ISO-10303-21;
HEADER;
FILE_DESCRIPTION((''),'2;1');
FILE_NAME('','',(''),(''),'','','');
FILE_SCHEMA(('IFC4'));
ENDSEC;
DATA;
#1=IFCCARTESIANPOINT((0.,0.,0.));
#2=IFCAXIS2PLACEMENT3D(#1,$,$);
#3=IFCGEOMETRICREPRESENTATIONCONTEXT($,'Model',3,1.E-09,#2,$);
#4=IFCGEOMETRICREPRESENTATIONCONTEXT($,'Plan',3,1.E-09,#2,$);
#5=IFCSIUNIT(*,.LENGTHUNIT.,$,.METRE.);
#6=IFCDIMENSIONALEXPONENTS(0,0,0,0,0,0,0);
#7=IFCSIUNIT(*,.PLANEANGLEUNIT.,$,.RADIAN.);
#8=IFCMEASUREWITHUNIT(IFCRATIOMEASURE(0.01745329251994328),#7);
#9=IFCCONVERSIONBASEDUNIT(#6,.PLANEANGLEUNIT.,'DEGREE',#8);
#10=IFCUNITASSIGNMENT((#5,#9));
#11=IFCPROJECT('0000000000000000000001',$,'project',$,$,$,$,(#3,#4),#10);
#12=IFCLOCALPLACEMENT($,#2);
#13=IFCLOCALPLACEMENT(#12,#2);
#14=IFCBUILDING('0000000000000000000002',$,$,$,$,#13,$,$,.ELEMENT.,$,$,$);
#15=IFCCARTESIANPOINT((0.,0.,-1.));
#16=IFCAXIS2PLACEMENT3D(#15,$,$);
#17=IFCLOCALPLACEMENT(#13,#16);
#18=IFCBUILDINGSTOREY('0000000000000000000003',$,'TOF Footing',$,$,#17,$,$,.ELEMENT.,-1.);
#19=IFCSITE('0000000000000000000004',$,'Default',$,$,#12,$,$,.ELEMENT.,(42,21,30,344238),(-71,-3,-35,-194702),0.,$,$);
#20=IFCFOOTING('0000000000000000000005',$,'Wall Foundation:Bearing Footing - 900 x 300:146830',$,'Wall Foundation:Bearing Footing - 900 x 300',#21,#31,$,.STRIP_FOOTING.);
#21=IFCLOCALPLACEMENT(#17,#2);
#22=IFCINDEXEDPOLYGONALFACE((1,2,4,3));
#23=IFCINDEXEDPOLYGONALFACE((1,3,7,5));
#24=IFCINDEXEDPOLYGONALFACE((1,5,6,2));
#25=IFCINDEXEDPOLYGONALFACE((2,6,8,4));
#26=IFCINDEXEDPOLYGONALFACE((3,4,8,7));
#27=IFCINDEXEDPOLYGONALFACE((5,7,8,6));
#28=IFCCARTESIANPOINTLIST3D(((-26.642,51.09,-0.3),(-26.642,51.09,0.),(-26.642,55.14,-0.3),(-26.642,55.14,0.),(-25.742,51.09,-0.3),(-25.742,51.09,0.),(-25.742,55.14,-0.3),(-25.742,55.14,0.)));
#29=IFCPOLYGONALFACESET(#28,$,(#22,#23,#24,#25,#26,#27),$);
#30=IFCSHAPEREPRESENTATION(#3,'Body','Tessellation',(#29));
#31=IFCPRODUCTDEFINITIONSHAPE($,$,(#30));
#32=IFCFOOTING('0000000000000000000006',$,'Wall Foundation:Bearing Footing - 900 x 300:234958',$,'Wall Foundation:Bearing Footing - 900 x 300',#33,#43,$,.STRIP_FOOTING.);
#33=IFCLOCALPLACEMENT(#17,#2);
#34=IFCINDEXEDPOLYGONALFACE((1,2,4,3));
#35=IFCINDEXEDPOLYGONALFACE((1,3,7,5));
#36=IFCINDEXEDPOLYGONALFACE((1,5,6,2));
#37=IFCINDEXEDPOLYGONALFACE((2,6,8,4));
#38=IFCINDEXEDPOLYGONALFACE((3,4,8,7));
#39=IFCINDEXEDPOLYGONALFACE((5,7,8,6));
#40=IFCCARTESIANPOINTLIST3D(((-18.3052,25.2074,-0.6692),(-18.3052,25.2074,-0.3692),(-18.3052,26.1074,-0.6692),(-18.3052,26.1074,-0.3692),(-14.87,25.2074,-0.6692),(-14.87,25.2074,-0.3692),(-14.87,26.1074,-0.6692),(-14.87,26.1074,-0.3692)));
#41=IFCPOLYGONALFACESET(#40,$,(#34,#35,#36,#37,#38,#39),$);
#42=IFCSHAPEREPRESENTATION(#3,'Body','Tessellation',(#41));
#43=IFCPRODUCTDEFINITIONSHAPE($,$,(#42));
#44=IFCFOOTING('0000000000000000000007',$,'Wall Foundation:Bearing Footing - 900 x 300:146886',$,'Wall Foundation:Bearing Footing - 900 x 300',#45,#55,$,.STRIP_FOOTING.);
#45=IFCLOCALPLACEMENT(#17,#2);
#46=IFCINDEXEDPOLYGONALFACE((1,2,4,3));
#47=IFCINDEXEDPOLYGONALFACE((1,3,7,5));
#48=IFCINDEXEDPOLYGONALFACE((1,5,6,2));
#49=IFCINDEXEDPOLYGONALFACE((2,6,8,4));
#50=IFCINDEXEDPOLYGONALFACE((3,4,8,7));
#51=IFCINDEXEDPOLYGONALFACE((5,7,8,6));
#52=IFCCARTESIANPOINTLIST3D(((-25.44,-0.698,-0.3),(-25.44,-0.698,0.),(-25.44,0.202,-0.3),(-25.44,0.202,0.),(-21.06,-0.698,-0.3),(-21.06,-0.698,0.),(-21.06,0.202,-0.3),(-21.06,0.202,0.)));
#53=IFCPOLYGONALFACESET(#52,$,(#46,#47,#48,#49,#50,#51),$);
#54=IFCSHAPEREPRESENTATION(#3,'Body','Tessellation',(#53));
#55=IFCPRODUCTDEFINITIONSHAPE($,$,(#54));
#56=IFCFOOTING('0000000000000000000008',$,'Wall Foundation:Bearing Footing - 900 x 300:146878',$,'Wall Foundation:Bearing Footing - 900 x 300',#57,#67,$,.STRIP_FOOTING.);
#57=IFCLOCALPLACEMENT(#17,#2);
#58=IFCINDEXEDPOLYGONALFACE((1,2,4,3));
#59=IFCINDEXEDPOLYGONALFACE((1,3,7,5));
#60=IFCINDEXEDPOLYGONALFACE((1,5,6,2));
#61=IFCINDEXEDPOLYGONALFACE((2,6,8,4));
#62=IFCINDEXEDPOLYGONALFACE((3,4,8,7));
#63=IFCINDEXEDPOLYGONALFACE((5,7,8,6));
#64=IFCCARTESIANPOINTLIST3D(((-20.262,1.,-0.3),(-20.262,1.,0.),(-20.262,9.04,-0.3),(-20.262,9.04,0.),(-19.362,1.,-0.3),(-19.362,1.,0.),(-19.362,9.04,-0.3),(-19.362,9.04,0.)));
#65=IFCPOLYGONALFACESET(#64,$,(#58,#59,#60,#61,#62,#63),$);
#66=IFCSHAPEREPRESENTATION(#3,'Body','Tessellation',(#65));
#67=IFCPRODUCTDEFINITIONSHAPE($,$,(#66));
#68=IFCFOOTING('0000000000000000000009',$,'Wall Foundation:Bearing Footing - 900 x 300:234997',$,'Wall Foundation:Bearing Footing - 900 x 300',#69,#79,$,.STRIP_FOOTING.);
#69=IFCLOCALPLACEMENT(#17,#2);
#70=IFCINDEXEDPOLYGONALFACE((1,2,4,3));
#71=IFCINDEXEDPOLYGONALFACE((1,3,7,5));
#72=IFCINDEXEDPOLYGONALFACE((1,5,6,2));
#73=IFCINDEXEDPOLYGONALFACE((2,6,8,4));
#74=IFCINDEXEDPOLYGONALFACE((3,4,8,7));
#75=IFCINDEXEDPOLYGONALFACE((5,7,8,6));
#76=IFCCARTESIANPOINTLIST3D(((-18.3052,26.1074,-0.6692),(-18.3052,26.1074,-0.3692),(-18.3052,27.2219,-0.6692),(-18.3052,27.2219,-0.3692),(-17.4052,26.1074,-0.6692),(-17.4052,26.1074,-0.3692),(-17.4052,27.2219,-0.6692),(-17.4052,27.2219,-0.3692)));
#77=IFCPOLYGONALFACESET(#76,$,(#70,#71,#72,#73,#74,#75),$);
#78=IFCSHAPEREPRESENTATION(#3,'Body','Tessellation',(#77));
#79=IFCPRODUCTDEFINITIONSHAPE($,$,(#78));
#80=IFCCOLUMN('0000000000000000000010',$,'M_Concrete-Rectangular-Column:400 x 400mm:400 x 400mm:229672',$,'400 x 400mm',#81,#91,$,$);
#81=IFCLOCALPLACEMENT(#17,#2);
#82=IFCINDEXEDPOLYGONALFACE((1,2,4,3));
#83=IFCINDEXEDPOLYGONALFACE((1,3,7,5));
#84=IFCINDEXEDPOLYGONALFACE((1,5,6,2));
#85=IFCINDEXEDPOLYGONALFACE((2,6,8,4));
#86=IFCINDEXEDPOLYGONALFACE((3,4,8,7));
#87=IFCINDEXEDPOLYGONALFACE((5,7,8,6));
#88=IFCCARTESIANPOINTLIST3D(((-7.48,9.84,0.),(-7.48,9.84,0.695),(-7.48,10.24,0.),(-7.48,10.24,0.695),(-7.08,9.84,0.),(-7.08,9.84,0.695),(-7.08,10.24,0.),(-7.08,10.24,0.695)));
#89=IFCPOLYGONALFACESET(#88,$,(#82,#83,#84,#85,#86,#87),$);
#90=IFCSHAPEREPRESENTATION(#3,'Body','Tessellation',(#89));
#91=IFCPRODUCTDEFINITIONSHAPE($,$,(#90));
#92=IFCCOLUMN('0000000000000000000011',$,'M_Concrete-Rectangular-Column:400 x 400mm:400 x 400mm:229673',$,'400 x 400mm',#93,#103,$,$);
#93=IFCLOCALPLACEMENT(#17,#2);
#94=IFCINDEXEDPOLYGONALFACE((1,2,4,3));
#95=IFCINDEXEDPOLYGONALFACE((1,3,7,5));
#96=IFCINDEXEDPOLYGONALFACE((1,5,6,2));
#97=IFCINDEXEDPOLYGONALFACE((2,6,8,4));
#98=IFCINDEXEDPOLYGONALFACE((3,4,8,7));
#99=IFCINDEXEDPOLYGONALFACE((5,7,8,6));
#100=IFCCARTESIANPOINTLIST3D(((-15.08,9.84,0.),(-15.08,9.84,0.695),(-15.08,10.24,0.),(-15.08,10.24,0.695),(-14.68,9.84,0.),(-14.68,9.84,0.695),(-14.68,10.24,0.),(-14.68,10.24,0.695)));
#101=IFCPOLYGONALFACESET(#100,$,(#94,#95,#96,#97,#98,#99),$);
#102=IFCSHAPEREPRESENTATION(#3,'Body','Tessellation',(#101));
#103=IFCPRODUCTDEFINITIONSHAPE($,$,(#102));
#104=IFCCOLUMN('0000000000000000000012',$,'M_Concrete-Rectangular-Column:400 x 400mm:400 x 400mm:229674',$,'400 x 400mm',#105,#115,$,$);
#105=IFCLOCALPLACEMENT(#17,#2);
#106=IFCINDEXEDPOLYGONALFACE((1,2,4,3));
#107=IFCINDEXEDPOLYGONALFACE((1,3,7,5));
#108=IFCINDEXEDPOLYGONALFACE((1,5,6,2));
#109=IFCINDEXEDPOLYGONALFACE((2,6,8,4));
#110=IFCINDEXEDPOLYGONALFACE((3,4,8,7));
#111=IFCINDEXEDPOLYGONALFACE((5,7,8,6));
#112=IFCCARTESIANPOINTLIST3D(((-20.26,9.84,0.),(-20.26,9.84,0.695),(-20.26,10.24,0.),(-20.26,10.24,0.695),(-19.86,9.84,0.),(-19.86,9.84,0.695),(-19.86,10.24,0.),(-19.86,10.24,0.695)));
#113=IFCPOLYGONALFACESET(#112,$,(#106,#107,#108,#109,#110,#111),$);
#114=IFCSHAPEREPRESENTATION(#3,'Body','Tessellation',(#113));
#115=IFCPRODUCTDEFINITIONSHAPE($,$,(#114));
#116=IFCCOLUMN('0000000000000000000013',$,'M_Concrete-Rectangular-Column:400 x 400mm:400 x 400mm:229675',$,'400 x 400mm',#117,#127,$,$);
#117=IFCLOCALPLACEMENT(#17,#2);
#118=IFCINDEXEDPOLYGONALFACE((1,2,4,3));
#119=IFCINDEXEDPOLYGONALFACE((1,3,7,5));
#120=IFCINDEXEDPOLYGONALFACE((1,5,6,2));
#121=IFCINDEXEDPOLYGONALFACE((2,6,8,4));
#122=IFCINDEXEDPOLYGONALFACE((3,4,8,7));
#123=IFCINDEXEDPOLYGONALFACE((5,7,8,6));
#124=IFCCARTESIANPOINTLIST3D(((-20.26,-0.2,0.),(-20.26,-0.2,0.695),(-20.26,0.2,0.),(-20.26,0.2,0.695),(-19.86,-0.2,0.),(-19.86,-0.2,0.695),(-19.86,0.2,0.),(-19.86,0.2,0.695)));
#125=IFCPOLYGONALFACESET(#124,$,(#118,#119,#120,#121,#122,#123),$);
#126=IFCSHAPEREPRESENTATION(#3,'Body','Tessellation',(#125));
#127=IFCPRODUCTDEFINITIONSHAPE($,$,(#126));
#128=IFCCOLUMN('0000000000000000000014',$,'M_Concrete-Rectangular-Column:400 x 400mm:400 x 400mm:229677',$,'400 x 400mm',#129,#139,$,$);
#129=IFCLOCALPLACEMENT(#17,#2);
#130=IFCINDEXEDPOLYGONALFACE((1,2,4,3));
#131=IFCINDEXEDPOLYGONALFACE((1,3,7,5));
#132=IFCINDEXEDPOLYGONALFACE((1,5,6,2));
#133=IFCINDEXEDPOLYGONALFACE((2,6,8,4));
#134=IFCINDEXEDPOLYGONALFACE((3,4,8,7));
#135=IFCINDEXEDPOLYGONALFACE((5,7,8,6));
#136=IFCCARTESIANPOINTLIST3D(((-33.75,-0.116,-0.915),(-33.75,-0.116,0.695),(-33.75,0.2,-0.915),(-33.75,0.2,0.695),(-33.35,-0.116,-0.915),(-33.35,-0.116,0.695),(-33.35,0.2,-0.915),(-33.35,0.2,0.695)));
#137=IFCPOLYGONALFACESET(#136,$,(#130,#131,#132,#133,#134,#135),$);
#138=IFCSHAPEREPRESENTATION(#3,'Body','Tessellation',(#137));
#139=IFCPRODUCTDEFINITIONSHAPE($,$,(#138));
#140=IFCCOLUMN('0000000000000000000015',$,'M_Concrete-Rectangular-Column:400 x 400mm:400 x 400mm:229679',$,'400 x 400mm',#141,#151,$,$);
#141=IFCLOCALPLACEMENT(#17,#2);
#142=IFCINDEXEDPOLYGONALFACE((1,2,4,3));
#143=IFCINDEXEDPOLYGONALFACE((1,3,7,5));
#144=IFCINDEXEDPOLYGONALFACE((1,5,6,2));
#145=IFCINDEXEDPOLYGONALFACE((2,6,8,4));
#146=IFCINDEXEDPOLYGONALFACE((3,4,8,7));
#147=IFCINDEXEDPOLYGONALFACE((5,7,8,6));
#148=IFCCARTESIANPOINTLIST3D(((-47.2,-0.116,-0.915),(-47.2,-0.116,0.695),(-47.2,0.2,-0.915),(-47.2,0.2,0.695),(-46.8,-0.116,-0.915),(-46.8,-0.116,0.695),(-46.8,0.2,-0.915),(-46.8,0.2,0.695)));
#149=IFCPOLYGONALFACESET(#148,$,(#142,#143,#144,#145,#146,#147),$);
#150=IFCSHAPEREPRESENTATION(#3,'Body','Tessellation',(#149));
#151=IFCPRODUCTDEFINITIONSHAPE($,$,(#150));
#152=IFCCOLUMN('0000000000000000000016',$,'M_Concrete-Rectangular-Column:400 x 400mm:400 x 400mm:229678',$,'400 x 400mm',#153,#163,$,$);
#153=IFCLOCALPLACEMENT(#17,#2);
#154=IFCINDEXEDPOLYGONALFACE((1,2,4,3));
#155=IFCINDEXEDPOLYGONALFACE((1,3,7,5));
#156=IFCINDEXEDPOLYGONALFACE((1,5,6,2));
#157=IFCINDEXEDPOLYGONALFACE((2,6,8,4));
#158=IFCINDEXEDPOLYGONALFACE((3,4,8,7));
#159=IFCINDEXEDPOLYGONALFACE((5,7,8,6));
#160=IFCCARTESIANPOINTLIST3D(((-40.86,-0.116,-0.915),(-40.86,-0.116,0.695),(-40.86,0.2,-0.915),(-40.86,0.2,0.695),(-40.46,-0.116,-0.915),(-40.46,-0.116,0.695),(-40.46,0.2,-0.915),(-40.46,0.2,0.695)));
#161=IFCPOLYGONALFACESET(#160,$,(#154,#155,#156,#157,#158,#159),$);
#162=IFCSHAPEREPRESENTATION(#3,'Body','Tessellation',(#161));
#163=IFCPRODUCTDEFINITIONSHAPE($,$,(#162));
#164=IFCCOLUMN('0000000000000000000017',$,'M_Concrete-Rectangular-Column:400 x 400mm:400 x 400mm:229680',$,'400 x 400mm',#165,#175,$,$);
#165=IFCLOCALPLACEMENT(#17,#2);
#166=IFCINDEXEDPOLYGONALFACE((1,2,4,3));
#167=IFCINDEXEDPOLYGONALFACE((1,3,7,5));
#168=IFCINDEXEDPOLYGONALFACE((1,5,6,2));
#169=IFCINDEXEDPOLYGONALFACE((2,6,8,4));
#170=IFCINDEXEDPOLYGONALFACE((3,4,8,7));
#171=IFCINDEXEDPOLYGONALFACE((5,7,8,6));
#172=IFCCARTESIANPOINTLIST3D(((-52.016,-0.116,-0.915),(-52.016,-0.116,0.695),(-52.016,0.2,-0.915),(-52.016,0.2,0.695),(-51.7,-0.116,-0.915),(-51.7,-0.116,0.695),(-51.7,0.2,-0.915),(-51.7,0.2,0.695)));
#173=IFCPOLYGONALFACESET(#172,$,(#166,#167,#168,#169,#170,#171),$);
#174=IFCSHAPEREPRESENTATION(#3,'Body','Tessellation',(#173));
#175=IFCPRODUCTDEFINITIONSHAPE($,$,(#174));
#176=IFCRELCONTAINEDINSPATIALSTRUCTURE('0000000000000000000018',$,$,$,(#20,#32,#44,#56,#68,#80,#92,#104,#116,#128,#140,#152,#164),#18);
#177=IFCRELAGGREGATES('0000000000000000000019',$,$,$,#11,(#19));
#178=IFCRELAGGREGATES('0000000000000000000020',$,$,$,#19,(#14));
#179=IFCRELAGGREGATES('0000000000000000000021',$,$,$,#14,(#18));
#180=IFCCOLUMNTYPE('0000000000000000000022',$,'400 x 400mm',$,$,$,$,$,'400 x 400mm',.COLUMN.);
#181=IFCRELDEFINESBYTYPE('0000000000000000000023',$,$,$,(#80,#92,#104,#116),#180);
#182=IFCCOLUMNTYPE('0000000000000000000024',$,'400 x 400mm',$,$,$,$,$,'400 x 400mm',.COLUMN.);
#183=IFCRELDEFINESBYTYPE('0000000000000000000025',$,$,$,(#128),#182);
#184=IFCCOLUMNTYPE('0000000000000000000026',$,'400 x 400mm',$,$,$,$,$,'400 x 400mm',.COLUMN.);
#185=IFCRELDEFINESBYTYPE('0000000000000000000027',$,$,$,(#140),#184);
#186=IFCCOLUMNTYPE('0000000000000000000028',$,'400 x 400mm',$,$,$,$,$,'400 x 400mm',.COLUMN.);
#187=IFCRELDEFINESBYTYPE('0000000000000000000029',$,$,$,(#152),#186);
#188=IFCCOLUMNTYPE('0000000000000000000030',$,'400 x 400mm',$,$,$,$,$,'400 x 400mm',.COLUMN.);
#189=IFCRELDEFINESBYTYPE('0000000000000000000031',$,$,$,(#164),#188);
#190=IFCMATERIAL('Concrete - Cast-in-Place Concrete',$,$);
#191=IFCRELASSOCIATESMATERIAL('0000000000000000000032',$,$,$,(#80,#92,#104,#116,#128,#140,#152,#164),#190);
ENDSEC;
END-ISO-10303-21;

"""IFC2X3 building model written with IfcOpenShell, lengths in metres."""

from ifc_helpers import new_model, entity, si_unit, converted_unit, frame, frame_2d, origin, origin_2d_with_axis, place, context, project, spatial, polyline, rectangle, extrude, clip, bounded_halfspace, source, transform, mapped, material, type_object, type_shapes, element, save


model = new_model("IFC2X3")

# Units and contexts
model_context = context("Model", 3, precision=1e-09, world=origin())
plan_context = context("Plan", 3, precision=1e-09, world=origin())
ifc_project = project(units=[si_unit("LENGTHUNIT", "METRE"), converted_unit("PLANEANGLEUNIT", "DEGREE", entity("IfcRatioMeasure", 0.01745329251994328), si_unit("PLANEANGLEUNIT", "RADIAN"), dimensions=[0, 0, 0, 0, 0, 0, 0])], contexts=[model_context, plan_context])

# Site, building, storey
site_placement = place(None, origin())
site = spatial("IfcSite", under=ifc_project, at=site_placement, Name="Default", CompositionType="ELEMENT", RefLatitude=(42, 21, 30, 344238), RefLongitude=(-71, -3, -35, -194702), RefElevation=0.0)
building_placement = place(site_placement, origin())
building = spatial("IfcBuilding", under=site, at=building_placement, CompositionType="ELEMENT")
storey_placement = place(building_placement, frame((0.0, 0.0, -1.0)))
storey = spatial("IfcBuildingStorey", under=building, at=storey_placement, Name="TOF Footing", CompositionType="ELEMENT", Elevation=-1.0)

# Footings
footing_1_placement = place(storey_placement, origin())
element("IfcFooting", 1, at=footing_1_placement, inside=storey, Name="Wall Foundation:Bearing Footing - 900 x 300:146830", ObjectType="Wall Foundation:Bearing Footing - 900 x 300", PredefinedType="STRIP_FOOTING", context=model_context, shape_type="SweptSolid", body=[
    extrude(rectangle(XDim=4.05, YDim=0.9, at=origin_2d_with_axis()), frame((-26.192, 53.115, -0.3), z_axis=(0.0, 0.0, 1.0), x_axis=(0.0, 1.0, 0.0)), (0.0, 0.0, 1.0), 0.3),
])
footing_2_placement = place(storey_placement, origin())
element("IfcFooting", 2, at=footing_2_placement, inside=storey, Name="Wall Foundation:Bearing Footing - 900 x 300:234958", ObjectType="Wall Foundation:Bearing Footing - 900 x 300", PredefinedType="STRIP_FOOTING", context=model_context, shape_type="SweptSolid", body=[
    extrude(rectangle(XDim=3.4352, YDim=0.9, at=frame_2d((0.0, 0.15), x_axis=(1.0, 0.0))), frame((-16.5876, 25.8074, -0.6692), z_axis=(0.0, 0.0, 1.0), x_axis=(-1.0, 0.0, 0.0)), (0.0, 0.0, 1.0), 0.3),
])
footing_3_placement = place(storey_placement, origin())
element("IfcFooting", 3, at=footing_3_placement, inside=storey, Name="Wall Foundation:Bearing Footing - 900 x 300:146886", ObjectType="Wall Foundation:Bearing Footing - 900 x 300", PredefinedType="STRIP_FOOTING", context=model_context, shape_type="SweptSolid", body=[
    extrude(rectangle(XDim=4.38, YDim=0.9, at=origin_2d_with_axis()), frame((-23.25, -0.248, -0.3)), (0.0, 0.0, 1.0), 0.3),
])
footing_4_placement = place(storey_placement, origin())
element("IfcFooting", 4, at=footing_4_placement, inside=storey, Name="Wall Foundation:Bearing Footing - 900 x 300:146878", ObjectType="Wall Foundation:Bearing Footing - 900 x 300", PredefinedType="STRIP_FOOTING", context=model_context, shape_type="SweptSolid", body=[
    extrude(rectangle(XDim=8.04, YDim=0.9, at=origin_2d_with_axis()), frame((-19.812, 5.02, -0.3), z_axis=(0.0, 0.0, 1.0), x_axis=(0.0, 1.0, 0.0)), (0.0, 0.0, 1.0), 0.3),
])
footing_5_placement = place(storey_placement, origin())
element("IfcFooting", 5, at=footing_5_placement, inside=storey, Name="Wall Foundation:Bearing Footing - 900 x 300:234997", ObjectType="Wall Foundation:Bearing Footing - 900 x 300", PredefinedType="STRIP_FOOTING", context=model_context, shape_type="SweptSolid", body=[
    extrude(rectangle(XDim=1.1145, YDim=0.9, at=origin_2d_with_axis()), frame((-17.8552, 26.6646, -0.6692), z_axis=(0.0, 0.0, 1.0), x_axis=(0.0, 1.0, 0.0)), (0.0, 0.0, 1.0), 0.3),
])

# Columns
ifc_material_1 = material(Name="Concrete - Cast-in-Place Concrete")
column_type_1 = type_object("IfcColumnType", Name="400 x 400mm", ElementType="400 x 400mm", PredefinedType="COLUMN")
shared_shape_1 = source(origin(), model_context, "Body", "SweptSolid", [
    extrude(rectangle(XDim=0.4, YDim=0.4, at=frame_2d((0.0, 0.0), x_axis=(0.0, -1.0))), origin(), (0.0, 0.0, 1.0), 0.695),
])
type_shapes(column_type_1, [shared_shape_1])
for number, where, z_axis, x_axis, name in (
    (6, (-7.28, 10.04, 0.0), (0.0, 0.0, 1.0), (0.0, 1.0, 0.0), "M_Concrete-Rectangular-Column:400 x 400mm:400 x 400mm:229672"),
    (7, (-14.88, 10.04, 0.0), (0.0, 0.0, 1.0), (0.0, 1.0, 0.0), "M_Concrete-Rectangular-Column:400 x 400mm:400 x 400mm:229673"),
    (8, (-20.06, 10.04, 0.0), (0.0, 0.0, 1.0), (0.0, 1.0, 0.0), "M_Concrete-Rectangular-Column:400 x 400mm:400 x 400mm:229674"),
    (9, (-20.06, 0.0, 0.0), (0.0, 0.0, 1.0), (0.0, 1.0, 0.0), "M_Concrete-Rectangular-Column:400 x 400mm:400 x 400mm:229675"),
):
    element("IfcColumn", number, at=place(storey_placement, frame(where, z_axis=z_axis, x_axis=x_axis)), inside=storey, type_object=column_type_1, material=ifc_material_1, Name=name, ObjectType="400 x 400mm", context=model_context, shape_type="MappedRepresentation", body=[
        mapped(shared_shape_1, transform((0.0, 0.0, 0.0), scale=1.0)),
    ])
column_type_2 = type_object("IfcColumnType", Name="400 x 400mm", ElementType="400 x 400mm", PredefinedType="COLUMN")
shared_shape_2 = source(origin(), model_context, "Body", "Clipping", [
    clip(extrude(rectangle(XDim=0.4, YDim=0.316, at=frame_2d((-33.55, 0.042), x_axis=(1.0, 0.0))), origin(), (0.0, 0.0, 1.0), 1.61), bounded_halfspace(frame((-33.75, -0.116, -1.915), z_axis=(0.0, 1.0, 0.0), x_axis=(-1.0, 0.0, 0.0)), True, frame((-33.75, -0.116, -1.915), z_axis=(0.0, 1.0, 0.0), x_axis=(-1.0, 0.0, 0.0)), polyline([(0.0, 0.0), (0.0, 1.61), (-0.4, 1.61), (-0.4, 0.0), (0.0, 0.0)]))),
])
type_shapes(column_type_2, [shared_shape_2])
column_1_placement = place(storey_placement, frame((0.0, 0.0, -0.915)))
element("IfcColumn", 10, at=column_1_placement, inside=storey, type_object=column_type_2, material=ifc_material_1, Name="M_Concrete-Rectangular-Column:400 x 400mm:400 x 400mm:229677", ObjectType="400 x 400mm", context=model_context, shape_type="MappedRepresentation", body=[
    mapped(shared_shape_2, transform((0.0, 0.0, 0.0), scale=1.0)),
])
column_type_3 = type_object("IfcColumnType", Name="400 x 400mm", ElementType="400 x 400mm", PredefinedType="COLUMN")
shared_shape_3 = source(origin(), model_context, "Body", "Clipping", [
    clip(extrude(rectangle(XDim=0.4, YDim=0.316, at=frame_2d((-47.0, 0.042), x_axis=(1.0, 0.0))), origin(), (0.0, 0.0, 1.0), 1.61), bounded_halfspace(frame((-47.2, -0.116, -1.915), z_axis=(0.0, 1.0, 0.0), x_axis=(-1.0, 0.0, 0.0)), True, frame((-47.2, -0.116, -1.915), z_axis=(0.0, 1.0, 0.0), x_axis=(-1.0, 0.0, 0.0)), polyline([(0.0, 0.0), (0.0, 1.61), (-0.4, 1.61), (-0.4, 0.0), (0.0, 0.0)]))),
])
type_shapes(column_type_3, [shared_shape_3])
column_2_placement = place(storey_placement, frame((0.0, 0.0, -0.915)))
element("IfcColumn", 11, at=column_2_placement, inside=storey, type_object=column_type_3, material=ifc_material_1, Name="M_Concrete-Rectangular-Column:400 x 400mm:400 x 400mm:229679", ObjectType="400 x 400mm", context=model_context, shape_type="MappedRepresentation", body=[
    mapped(shared_shape_3, transform((0.0, 0.0, 0.0), scale=1.0)),
])
column_type_4 = type_object("IfcColumnType", Name="400 x 400mm", ElementType="400 x 400mm", PredefinedType="COLUMN")
shared_shape_4 = source(origin(), model_context, "Body", "Clipping", [
    clip(extrude(rectangle(XDim=0.4, YDim=0.316, at=frame_2d((-40.66, 0.042), x_axis=(1.0, 0.0))), origin(), (0.0, 0.0, 1.0), 1.61), bounded_halfspace(frame((-40.86, -0.116, -1.915), z_axis=(0.0, 1.0, 0.0), x_axis=(-1.0, 0.0, 0.0)), True, frame((-40.86, -0.116, -1.915), z_axis=(0.0, 1.0, 0.0), x_axis=(-1.0, 0.0, 0.0)), polyline([(0.0, 0.0), (0.0, 1.61), (-0.4, 1.61), (-0.4, 0.0), (0.0, 0.0)]))),
])
type_shapes(column_type_4, [shared_shape_4])
column_3_placement = place(storey_placement, frame((0.0, 0.0, -0.915)))
element("IfcColumn", 12, at=column_3_placement, inside=storey, type_object=column_type_4, material=ifc_material_1, Name="M_Concrete-Rectangular-Column:400 x 400mm:400 x 400mm:229678", ObjectType="400 x 400mm", context=model_context, shape_type="MappedRepresentation", body=[
    mapped(shared_shape_4, transform((0.0, 0.0, 0.0), scale=1.0)),
])
column_type_5 = type_object("IfcColumnType", Name="400 x 400mm", ElementType="400 x 400mm", PredefinedType="COLUMN")
shared_shape_5 = source(origin(), model_context, "Body", "Clipping", [
    clip(clip(extrude(rectangle(XDim=0.316, YDim=0.316, at=frame_2d((-51.858, 0.042), x_axis=(1.0, 0.0))), origin(), (0.0, 0.0, 1.0), 1.61), bounded_halfspace(frame((-52.016, 0.2, -1.915), z_axis=(1.0, 0.0, 0.0), x_axis=(0.0, 1.0, 0.0)), True, frame((-52.016, 0.2, -1.915), z_axis=(1.0, 0.0, 0.0), x_axis=(0.0, 1.0, 0.0)), polyline([(0.0, 0.0), (0.0, 1.61), (-0.316, 1.61), (-0.316, 0.0), (0.0, 0.0)]))), bounded_halfspace(frame((-52.016, -0.116, -1.915), z_axis=(0.0, 1.0, 0.0), x_axis=(-1.0, 0.0, 0.0)), True, frame((-52.016, -0.116, -1.915), z_axis=(0.0, 1.0, 0.0), x_axis=(-1.0, 0.0, 0.0)), polyline([(0.0, 0.0), (0.0, 1.61), (-0.316, 1.61), (-0.316, 0.0), (0.0, 0.0)]))),
])
type_shapes(column_type_5, [shared_shape_5])
column_4_placement = place(storey_placement, frame((0.0, 0.0, -0.915)))
element("IfcColumn", 13, at=column_4_placement, inside=storey, type_object=column_type_5, material=ifc_material_1, Name="M_Concrete-Rectangular-Column:400 x 400mm:400 x 400mm:229680", ObjectType="400 x 400mm", context=model_context, shape_type="MappedRepresentation", body=[
    mapped(shared_shape_5, transform((0.0, 0.0, 0.0), scale=1.0)),
])

save(model, "model.ifc")
